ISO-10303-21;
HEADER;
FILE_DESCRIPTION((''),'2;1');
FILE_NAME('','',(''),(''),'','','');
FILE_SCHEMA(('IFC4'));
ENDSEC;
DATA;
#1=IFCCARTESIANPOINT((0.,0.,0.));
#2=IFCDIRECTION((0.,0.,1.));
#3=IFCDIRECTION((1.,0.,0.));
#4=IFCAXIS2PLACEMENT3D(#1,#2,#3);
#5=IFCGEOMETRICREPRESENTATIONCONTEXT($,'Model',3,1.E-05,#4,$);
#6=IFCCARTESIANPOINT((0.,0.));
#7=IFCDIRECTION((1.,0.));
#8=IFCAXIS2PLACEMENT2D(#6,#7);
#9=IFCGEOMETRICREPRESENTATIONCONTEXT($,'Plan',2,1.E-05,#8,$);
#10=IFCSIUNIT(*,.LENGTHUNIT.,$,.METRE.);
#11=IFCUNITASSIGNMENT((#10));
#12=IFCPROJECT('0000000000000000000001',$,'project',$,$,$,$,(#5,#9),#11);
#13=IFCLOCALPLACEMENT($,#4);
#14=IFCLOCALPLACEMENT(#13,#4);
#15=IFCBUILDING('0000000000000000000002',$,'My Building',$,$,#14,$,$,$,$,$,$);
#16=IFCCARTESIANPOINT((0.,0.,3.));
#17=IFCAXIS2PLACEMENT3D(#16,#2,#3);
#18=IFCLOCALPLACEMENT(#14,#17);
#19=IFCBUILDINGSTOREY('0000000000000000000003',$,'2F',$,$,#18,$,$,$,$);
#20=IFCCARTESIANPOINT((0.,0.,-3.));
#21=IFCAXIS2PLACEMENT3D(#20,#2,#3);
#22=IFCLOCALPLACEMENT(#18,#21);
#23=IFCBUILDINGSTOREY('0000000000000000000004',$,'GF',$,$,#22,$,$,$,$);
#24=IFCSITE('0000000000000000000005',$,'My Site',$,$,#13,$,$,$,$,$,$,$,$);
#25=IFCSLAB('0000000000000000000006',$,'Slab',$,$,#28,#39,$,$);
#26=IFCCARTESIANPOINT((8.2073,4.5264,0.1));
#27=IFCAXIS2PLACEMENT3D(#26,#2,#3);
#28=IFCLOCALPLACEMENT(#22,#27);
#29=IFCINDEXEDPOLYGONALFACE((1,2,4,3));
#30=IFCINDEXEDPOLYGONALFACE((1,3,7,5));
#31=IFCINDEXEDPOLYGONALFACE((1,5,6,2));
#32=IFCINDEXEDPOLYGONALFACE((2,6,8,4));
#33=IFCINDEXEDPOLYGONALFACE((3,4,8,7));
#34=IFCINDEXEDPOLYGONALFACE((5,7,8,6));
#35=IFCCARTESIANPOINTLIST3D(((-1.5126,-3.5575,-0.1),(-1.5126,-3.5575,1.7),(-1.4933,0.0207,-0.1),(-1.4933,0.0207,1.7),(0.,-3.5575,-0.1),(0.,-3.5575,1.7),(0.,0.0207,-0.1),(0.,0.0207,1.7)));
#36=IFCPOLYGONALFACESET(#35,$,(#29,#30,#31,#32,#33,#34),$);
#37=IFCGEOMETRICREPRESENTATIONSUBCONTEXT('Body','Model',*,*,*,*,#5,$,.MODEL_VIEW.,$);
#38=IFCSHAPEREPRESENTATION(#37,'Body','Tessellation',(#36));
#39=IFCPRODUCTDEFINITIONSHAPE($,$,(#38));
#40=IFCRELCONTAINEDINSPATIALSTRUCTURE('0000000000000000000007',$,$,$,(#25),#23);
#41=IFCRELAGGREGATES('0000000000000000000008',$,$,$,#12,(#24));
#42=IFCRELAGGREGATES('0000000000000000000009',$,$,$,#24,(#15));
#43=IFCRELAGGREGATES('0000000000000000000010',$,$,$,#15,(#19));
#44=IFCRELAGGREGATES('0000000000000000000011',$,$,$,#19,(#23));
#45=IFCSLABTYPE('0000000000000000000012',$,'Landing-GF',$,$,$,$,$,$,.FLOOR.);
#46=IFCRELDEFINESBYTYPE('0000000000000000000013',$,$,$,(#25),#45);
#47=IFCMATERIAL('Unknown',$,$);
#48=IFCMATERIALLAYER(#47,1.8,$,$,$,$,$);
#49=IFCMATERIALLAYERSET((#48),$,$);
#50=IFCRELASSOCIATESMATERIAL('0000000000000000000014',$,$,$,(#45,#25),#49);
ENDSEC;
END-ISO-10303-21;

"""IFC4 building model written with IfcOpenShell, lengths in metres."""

from ifc_helpers import new_model, si_unit, frame, origin_with_axes, origin_2d_with_axis, place, context, subcontext, project, spatial, indexed_curve, outline, extrude, material, layer, layer_set, layer_usage, type_object, element, save


model = new_model("IFC4")

# Units and contexts
model_context = context("Model", 3, precision=1e-05, world=origin_with_axes())
plan_context = context("Plan", 2, precision=1e-05, world=origin_2d_with_axis())
body_context_1 = subcontext(model_context, "Body", "Model", "MODEL_VIEW")
ifc_project = project(units=[si_unit("LENGTHUNIT", "METRE")], contexts=[model_context, plan_context])

# Site, building, storeys
site_placement = place(None, origin_with_axes())
site = spatial("IfcSite", under=ifc_project, at=site_placement, Name="My Site")
building_placement = place(site_placement, origin_with_axes())
building = spatial("IfcBuilding", under=site, at=building_placement, Name="My Building")
storey_1_placement = place(building_placement, frame((0.0, 0.0, 3.0), z_axis=(0.0, 0.0, 1.0), x_axis=(1.0, 0.0, 0.0)))
storey_1 = spatial("IfcBuildingStorey", under=building, at=storey_1_placement, Name="2F")
storey_2_placement = place(storey_1_placement, frame((0.0, 0.0, -3.0), z_axis=(0.0, 0.0, 1.0), x_axis=(1.0, 0.0, 0.0)))
storey_2 = spatial("IfcBuildingStorey", under=storey_1, at=storey_2_placement, Name="GF")

# Shared definitions
ifc_material = material(Name="Unknown")

# Slab
ifc_layer_1 = layer(ifc_material, 1.8)
ifc_layer_set_1 = layer_set([ifc_layer_1])
ifc_layer_usage_1 = layer_usage(ifc_layer_set_1, "AXIS3", "POSITIVE", -0.1)
slab_type = type_object("IfcSlabType", Name="Landing-GF", PredefinedType="FLOOR", material=ifc_layer_set_1)
slab_1_placement = place(storey_2_placement, frame((8.2073, 4.5264, 0.1), z_axis=(0.0, 0.0, 1.0), x_axis=(1.0, 0.0, 0.0)))
element("IfcSlab", 1, at=slab_1_placement, inside=storey_2, type_object=slab_type, material=ifc_layer_usage_1, Name="Slab", context=body_context_1, shape_type="SweptSolid", body=[
    extrude(outline(indexed_curve([(0.0, 0.0207), (0.0, -3.5575), (-1.5126, -3.5575), (-1.4933, 0.0207), (0.0, 0.0207)])), frame((0.0, 0.0, -0.1), z_axis=(0.0, 0.0, 1.0), x_axis=(1.0, 0.0, 0.0)), (0.0, 0.0, 1.0), 1.8),
])

save(model, "model.ifc")
